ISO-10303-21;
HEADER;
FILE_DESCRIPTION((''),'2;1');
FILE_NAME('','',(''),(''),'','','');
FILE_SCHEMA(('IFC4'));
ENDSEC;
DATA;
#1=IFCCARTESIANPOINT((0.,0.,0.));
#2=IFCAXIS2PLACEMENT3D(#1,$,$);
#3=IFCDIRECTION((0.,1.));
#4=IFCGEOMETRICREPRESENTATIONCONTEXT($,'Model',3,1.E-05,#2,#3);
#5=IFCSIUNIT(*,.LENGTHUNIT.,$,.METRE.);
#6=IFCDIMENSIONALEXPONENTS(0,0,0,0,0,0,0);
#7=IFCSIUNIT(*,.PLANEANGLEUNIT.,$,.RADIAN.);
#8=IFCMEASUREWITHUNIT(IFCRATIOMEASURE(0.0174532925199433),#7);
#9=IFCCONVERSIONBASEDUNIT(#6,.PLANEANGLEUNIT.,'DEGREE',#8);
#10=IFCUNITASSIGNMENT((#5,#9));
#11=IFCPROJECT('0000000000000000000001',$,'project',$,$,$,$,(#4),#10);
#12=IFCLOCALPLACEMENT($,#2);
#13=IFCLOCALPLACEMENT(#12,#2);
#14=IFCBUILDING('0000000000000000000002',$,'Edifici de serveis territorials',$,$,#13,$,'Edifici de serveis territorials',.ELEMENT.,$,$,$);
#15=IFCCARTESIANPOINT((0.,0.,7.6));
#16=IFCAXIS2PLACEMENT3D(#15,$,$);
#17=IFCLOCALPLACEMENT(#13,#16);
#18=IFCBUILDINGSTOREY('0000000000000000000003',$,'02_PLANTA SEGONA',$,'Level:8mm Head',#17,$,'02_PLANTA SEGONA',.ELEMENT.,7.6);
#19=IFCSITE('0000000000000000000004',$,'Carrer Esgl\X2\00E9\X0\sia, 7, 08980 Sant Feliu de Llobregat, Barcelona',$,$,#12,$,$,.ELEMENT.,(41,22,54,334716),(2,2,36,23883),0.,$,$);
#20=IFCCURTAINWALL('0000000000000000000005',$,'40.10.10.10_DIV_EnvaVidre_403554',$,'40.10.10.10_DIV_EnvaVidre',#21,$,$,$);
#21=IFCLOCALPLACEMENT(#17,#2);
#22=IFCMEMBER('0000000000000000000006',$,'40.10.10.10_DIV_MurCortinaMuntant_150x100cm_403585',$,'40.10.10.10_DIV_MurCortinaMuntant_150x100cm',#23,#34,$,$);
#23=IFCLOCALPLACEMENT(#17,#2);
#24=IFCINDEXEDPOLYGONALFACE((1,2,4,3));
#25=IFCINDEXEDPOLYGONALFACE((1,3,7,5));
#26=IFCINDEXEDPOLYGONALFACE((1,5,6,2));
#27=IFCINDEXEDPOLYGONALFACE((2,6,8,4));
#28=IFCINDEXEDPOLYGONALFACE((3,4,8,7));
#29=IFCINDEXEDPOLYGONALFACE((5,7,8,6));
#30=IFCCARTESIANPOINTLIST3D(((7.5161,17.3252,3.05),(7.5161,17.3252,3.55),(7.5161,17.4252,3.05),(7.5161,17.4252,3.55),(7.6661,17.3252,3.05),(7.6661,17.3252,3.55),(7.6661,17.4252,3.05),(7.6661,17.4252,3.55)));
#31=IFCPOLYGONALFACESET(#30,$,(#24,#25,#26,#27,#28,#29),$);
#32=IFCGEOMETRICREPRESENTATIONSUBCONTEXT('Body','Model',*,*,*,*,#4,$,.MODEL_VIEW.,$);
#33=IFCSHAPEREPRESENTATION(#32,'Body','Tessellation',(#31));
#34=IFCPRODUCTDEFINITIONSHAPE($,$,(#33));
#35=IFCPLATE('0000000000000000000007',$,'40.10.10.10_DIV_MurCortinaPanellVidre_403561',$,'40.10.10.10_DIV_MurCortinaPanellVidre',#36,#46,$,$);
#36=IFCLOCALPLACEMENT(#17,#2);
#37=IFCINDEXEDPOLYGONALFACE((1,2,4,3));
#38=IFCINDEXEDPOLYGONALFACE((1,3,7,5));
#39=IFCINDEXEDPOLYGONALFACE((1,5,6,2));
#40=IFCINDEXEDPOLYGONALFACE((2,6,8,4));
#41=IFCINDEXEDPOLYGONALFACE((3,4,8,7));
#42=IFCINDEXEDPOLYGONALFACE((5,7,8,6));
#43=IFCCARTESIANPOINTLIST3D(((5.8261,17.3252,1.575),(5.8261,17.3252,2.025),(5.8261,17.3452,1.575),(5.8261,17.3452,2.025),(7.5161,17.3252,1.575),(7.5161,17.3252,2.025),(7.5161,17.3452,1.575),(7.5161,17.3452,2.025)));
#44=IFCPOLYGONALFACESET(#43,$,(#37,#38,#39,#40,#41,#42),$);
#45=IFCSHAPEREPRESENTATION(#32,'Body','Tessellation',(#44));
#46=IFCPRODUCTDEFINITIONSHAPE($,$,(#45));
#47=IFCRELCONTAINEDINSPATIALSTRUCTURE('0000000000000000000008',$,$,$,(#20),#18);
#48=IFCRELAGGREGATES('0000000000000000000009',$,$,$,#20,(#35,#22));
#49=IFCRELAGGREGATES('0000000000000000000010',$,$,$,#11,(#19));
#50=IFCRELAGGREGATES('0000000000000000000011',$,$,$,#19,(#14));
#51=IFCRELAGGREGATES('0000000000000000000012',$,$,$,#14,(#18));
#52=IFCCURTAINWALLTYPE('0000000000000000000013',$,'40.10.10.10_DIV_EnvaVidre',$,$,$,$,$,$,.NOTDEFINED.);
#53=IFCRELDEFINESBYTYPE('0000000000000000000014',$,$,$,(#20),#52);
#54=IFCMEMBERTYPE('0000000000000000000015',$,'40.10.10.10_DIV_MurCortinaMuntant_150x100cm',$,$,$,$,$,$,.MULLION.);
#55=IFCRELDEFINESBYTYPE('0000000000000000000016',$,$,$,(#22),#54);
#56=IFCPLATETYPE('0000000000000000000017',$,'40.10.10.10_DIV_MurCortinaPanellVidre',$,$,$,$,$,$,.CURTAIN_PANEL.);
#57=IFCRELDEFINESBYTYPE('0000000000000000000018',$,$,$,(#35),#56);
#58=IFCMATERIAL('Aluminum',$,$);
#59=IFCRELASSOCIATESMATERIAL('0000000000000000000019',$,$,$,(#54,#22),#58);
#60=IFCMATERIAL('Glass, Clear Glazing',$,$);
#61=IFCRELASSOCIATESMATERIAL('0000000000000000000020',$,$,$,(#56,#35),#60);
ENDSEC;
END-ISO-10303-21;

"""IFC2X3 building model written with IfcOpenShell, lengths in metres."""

from ifc_helpers import new_model, entity, si_unit, converted_unit, direction, frame, frame_2d, origin, origin_2d_with_axis, place, context, subcontext, project, spatial, rectangle, extrude, source, transform, mapped, material, type_object, type_shapes, element, aggregate, save


model = new_model("IFC2X3")

# Units and contexts
model_context = context("Model", 3, precision=1e-05, world=origin(), true_north=direction((0.0, 1.0)))
body_context = subcontext(model_context, "Body", "Model", "MODEL_VIEW")
ifc_project = project(units=[si_unit("LENGTHUNIT", "METRE"), converted_unit("PLANEANGLEUNIT", "DEGREE", entity("IfcRatioMeasure", 0.0174532925199433), si_unit("PLANEANGLEUNIT", "RADIAN"), dimensions=[0, 0, 0, 0, 0, 0, 0])], contexts=[model_context])

# Site, building, storey
site_placement = place(None, origin())
site = spatial("IfcSite", under=ifc_project, at=site_placement, Name="Carrer Església, 7, 08980 Sant Feliu de Llobregat, Barcelona", CompositionType="ELEMENT", RefLatitude=(41, 22, 54, 334716), RefLongitude=(2, 2, 36, 23883), RefElevation=0.0)
building_placement = place(site_placement, origin())
building = spatial("IfcBuilding", under=site, at=building_placement, Name="Edifici de serveis territorials", LongName="Edifici de serveis territorials", CompositionType="ELEMENT")
storey_placement = place(building_placement, frame((0.0, 0.0, 7.6)))
storey = spatial("IfcBuildingStorey", under=building, at=storey_placement, Name="02_PLANTA SEGONA", ObjectType="Level:8mm Head", LongName="02_PLANTA SEGONA", CompositionType="ELEMENT", Elevation=7.6)

# Curtain wall
curtain_wall_type = type_object("IfcCurtainWallType", Name="40.10.10.10_DIV_EnvaVidre", PredefinedType="NOTDEFINED")
ifc_material_1 = material(Name="Aluminum")
curtain_wall_1_placement = place(storey_placement, frame((0.0, 0.0, -7.6)))
curtain_wall_1 = element("IfcCurtainWall", 1, at=curtain_wall_1_placement, inside=storey, type_object=curtain_wall_type, Name="40.10.10.10_DIV_EnvaVidre_403554", ObjectType="40.10.10.10_DIV_EnvaVidre")

# Member
member_type_1 = type_object("IfcMemberType", Name="40.10.10.10_DIV_MurCortinaMuntant_150x100cm", PredefinedType="MULLION", material=ifc_material_1)
shared_shape_1 = source(origin(), body_context, "Body", "SweptSolid", [
    extrude(rectangle(XDim=0.1, YDim=0.15, at=origin_2d_with_axis()), frame((-0.075, 0.0, -0.5), z_axis=(0.0, 0.0, 1.0), x_axis=(0.0, -1.0, 0.0)), (0.0, 0.0, 1.0), 0.5),
])
type_shapes(member_type_1, [shared_shape_1])
member_1_placement = place(storey_placement, frame((7.6661, 17.3752, 3.55)))
member_1 = element("IfcMember", 2, at=member_1_placement, type_object=member_type_1, material=ifc_material_1, Name="40.10.10.10_DIV_MurCortinaMuntant_150x100cm_403585", ObjectType="40.10.10.10_DIV_MurCortinaMuntant_150x100cm", context=body_context, shape_type="MappedRepresentation", body=[
    mapped(shared_shape_1, transform((0.0, 0.0, 0.0), scale=1.0)),
])

# Plate
ifc_material_2 = material(Name="Glass, Clear Glazing")
plate_type_1 = type_object("IfcPlateType", Name="40.10.10.10_DIV_MurCortinaPanellVidre", PredefinedType="CURTAIN_PANEL", material=ifc_material_2)
shared_shape_2 = source(origin(), body_context, "Body", "SweptSolid", [
    extrude(rectangle(XDim=0.02, YDim=1.69, at=frame_2d((0.0, 0.0), x_axis=(1.0, 0.0))), frame((0.845, 0.01, 0.0), z_axis=(0.0, 0.0, 1.0), x_axis=(0.0, 1.0, 0.0)), (0.0, 0.0, 1.0), 0.45),
])
type_shapes(plate_type_1, [shared_shape_2])
plate_1_placement = place(curtain_wall_1_placement, frame((7.5161, 17.3452, 9.175), z_axis=(0.0, 0.0, 1.0), x_axis=(-1.0, 0.0, 0.0)))
plate_1 = element("IfcPlate", 3, at=plate_1_placement, type_object=plate_type_1, material=ifc_material_2, Name="40.10.10.10_DIV_MurCortinaPanellVidre_403561", ObjectType="40.10.10.10_DIV_MurCortinaPanellVidre", context=body_context, shape_type="MappedRepresentation", body=[
    mapped(shared_shape_2, transform((0.0, 0.0, 0.0), scale=1.0)),
])
aggregate(curtain_wall_1, [plate_1, member_1])

save(model, "model.ifc")
